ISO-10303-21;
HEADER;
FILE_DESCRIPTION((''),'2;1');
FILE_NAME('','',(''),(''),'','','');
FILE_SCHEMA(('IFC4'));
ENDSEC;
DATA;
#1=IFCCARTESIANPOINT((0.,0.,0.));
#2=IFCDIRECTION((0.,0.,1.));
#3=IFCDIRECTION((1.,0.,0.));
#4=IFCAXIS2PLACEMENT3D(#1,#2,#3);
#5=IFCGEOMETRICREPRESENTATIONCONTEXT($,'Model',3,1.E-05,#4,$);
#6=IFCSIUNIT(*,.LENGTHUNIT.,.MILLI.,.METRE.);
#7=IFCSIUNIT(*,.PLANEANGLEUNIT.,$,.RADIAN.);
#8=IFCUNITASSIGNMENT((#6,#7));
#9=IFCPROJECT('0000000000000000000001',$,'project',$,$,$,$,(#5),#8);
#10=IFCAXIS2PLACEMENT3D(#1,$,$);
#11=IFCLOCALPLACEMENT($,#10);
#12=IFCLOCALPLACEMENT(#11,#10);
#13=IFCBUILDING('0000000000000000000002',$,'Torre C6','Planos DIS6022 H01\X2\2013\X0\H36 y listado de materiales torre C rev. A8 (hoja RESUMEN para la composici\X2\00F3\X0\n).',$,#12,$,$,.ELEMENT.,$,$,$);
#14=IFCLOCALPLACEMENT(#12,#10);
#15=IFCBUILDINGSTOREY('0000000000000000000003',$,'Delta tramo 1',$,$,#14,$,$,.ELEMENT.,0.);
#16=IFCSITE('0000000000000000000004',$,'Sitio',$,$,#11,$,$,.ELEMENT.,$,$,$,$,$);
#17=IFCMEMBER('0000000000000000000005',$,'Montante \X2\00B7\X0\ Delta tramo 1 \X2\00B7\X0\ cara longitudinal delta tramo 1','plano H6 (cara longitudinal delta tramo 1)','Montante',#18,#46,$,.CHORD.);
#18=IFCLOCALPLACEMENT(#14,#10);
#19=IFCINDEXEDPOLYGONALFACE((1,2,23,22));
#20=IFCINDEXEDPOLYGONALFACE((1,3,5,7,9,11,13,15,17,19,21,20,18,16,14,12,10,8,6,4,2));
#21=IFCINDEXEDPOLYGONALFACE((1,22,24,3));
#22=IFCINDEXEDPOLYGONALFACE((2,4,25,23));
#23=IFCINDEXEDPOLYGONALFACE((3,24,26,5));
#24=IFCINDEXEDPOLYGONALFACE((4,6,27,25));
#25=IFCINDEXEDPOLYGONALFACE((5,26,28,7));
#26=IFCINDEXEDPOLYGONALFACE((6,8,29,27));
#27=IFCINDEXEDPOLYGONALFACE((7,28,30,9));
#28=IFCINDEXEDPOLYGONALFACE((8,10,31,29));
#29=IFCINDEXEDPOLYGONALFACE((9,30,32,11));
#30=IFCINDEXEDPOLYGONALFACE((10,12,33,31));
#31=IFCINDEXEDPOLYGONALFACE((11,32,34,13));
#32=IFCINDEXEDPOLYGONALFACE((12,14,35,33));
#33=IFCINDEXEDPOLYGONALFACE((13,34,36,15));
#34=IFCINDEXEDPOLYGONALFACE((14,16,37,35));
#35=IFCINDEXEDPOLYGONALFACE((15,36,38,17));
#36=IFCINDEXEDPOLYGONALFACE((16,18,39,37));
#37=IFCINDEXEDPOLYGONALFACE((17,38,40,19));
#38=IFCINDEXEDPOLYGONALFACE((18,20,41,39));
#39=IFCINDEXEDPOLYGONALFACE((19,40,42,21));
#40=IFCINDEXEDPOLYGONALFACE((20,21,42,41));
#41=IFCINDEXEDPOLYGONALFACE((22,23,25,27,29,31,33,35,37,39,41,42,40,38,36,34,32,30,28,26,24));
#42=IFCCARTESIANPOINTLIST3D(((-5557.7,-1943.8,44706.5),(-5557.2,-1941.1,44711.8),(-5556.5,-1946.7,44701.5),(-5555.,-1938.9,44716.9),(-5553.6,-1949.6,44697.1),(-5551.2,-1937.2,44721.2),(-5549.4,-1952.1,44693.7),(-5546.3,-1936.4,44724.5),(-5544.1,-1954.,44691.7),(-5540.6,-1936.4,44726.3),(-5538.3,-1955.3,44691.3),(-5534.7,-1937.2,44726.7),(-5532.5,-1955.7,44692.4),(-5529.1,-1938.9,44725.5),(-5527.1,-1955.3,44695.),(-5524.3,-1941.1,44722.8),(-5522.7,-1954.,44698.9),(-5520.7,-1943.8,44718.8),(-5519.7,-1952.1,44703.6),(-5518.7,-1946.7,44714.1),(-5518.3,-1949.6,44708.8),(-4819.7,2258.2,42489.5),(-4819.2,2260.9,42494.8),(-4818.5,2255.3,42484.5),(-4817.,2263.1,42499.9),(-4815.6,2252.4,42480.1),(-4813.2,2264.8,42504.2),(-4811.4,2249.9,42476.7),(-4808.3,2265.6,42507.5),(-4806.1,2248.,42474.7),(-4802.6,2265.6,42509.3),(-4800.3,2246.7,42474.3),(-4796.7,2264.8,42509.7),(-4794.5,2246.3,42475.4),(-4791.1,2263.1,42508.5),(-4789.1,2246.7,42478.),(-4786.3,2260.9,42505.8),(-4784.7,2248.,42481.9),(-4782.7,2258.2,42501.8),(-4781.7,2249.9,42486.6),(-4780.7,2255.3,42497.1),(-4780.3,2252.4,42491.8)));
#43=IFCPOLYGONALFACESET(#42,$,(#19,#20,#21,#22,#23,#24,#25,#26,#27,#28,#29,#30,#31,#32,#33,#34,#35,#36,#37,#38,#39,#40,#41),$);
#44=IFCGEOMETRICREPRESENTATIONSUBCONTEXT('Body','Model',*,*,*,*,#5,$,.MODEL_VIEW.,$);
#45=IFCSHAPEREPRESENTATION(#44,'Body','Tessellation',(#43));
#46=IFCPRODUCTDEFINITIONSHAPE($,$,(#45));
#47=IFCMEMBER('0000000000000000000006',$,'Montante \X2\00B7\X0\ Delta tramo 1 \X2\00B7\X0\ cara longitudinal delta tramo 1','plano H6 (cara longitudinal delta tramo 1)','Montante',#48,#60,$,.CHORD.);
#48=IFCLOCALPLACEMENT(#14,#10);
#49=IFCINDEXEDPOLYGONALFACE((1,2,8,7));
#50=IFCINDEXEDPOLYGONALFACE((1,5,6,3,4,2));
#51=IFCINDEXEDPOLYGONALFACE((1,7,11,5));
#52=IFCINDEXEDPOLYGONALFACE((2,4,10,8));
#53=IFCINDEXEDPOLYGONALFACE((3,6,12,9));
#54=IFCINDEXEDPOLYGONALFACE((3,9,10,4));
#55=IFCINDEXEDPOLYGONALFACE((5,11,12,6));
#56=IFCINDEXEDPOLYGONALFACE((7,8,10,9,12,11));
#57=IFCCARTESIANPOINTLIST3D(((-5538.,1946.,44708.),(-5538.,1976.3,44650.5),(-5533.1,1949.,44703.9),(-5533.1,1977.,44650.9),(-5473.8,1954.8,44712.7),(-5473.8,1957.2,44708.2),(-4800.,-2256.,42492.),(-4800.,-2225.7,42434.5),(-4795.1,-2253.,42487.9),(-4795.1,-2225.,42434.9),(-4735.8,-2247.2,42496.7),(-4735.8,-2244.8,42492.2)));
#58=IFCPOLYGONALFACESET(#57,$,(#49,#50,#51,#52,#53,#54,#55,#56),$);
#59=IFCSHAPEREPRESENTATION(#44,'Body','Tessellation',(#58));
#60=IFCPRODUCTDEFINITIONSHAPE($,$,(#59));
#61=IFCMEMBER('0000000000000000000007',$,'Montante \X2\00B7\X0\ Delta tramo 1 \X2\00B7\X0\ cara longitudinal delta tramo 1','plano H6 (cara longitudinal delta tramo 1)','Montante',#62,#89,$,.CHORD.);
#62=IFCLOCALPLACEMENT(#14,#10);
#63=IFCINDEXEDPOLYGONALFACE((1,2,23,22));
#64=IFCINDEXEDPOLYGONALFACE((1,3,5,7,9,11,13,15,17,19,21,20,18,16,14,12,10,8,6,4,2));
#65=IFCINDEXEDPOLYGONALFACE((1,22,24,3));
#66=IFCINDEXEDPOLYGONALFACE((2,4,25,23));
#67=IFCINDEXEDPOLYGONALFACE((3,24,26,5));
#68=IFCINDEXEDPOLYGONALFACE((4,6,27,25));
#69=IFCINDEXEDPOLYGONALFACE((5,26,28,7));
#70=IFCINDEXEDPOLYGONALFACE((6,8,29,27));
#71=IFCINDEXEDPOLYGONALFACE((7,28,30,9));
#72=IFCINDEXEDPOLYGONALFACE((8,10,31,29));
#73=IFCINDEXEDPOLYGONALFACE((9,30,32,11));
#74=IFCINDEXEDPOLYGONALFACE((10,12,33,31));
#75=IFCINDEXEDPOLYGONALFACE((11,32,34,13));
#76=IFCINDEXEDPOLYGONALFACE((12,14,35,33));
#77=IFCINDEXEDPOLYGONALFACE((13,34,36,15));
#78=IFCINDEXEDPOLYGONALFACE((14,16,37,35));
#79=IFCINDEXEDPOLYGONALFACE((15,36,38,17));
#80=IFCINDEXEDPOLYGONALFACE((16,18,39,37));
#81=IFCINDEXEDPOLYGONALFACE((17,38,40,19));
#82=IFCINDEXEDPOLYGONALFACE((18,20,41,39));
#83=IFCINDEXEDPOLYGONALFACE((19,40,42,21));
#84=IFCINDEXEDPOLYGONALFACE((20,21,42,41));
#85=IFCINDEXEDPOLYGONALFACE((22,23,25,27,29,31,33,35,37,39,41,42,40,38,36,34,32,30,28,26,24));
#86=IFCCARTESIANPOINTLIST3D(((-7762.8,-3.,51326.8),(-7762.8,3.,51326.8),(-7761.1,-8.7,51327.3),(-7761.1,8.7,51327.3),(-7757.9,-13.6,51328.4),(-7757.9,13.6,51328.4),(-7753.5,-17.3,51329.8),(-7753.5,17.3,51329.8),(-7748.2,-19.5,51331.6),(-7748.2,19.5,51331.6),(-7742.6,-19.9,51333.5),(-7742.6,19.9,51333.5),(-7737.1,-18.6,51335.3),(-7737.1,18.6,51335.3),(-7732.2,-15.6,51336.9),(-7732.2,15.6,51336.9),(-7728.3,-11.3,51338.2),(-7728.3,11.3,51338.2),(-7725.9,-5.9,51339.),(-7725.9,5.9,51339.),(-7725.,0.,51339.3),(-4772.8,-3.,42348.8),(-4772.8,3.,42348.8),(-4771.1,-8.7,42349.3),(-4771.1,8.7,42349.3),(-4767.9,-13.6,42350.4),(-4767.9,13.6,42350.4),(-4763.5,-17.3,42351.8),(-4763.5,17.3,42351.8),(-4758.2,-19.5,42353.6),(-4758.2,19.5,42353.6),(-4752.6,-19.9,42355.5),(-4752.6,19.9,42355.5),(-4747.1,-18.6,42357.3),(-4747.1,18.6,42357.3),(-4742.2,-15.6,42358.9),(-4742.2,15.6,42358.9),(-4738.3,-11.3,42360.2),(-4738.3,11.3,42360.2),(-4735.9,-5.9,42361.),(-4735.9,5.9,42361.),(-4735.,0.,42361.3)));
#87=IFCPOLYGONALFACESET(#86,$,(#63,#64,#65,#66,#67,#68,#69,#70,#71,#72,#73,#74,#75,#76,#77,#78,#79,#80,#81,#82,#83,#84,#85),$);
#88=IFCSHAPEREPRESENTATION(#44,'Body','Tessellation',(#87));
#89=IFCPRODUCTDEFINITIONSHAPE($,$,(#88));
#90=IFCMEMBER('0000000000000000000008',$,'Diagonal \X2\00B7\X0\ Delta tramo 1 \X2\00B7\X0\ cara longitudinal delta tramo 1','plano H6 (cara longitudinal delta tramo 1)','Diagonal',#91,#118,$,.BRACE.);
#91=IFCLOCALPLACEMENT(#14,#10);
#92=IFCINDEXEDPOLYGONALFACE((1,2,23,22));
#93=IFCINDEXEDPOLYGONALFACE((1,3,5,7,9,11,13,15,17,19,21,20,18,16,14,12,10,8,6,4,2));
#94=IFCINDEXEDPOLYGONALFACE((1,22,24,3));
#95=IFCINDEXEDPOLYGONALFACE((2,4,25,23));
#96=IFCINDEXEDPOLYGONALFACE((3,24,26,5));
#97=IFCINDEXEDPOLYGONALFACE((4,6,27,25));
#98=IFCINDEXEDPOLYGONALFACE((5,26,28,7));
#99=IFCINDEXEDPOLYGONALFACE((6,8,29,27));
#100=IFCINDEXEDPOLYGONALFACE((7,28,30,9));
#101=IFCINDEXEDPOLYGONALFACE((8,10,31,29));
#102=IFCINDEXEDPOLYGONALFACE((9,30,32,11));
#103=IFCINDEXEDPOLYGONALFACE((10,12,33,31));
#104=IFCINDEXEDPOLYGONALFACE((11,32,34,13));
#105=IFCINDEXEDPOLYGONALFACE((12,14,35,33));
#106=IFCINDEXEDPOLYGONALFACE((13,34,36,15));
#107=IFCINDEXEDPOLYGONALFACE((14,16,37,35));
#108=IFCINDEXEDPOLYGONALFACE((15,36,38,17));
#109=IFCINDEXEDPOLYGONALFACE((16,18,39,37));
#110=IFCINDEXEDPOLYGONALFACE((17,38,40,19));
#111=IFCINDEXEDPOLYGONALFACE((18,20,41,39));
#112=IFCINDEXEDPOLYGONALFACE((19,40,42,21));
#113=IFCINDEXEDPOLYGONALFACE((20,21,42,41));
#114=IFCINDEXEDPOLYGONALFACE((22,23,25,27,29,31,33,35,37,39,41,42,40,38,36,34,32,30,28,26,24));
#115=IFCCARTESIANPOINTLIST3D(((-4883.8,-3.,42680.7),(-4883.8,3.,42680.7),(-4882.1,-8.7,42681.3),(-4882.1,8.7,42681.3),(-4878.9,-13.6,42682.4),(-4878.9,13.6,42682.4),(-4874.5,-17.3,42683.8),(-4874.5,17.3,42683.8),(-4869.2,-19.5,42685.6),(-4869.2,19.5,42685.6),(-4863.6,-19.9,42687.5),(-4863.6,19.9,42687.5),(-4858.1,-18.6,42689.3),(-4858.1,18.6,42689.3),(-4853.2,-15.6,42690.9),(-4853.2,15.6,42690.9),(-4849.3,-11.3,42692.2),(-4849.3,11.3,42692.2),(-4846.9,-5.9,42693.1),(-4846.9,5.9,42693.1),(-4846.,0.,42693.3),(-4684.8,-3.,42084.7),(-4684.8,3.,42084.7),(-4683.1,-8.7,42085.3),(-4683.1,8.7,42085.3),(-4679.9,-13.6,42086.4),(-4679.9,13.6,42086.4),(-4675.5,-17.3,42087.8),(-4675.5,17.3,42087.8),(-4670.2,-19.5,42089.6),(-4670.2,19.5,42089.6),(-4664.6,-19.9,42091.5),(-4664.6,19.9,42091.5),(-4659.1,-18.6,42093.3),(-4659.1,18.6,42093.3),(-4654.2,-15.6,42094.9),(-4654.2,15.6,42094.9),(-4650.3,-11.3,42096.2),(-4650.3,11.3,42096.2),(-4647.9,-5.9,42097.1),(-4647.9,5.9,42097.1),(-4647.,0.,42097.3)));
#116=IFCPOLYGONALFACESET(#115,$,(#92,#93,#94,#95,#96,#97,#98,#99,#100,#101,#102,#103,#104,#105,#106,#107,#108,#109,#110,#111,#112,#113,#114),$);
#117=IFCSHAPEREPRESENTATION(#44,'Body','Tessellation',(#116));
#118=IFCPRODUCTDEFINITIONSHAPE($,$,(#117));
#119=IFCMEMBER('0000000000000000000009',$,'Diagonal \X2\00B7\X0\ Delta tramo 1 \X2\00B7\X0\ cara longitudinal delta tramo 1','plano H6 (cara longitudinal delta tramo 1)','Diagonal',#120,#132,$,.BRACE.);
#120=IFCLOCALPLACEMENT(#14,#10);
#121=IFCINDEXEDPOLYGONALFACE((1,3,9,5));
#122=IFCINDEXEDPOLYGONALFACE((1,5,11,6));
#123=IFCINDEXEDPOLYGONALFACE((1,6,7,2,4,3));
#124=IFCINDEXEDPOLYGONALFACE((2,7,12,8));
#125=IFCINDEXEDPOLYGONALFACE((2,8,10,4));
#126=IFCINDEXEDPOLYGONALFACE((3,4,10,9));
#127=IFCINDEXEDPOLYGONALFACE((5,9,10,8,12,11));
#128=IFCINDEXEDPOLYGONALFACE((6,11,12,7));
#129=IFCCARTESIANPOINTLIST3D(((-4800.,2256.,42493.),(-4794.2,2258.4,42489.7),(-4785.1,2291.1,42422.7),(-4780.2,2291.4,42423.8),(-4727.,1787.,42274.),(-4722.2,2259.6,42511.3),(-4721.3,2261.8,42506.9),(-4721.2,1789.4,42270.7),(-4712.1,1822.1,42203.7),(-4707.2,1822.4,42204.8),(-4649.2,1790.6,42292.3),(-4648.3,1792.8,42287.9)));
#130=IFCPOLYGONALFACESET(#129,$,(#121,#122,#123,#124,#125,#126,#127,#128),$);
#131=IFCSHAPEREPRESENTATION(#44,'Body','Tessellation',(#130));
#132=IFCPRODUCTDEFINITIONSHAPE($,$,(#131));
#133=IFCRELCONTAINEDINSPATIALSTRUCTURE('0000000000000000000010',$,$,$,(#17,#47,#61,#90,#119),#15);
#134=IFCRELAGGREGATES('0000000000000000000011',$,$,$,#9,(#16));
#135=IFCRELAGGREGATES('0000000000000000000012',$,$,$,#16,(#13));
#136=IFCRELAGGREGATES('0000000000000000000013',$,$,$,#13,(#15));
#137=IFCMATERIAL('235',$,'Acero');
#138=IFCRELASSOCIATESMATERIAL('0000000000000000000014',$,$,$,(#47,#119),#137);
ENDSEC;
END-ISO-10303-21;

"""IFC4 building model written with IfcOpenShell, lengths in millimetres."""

from ifc_helpers import new_model, si_unit, frame, frame_2d, origin, origin_with_axes, place, context, subcontext, project, spatial, circle, l_section, extrude, material, element, save


model = new_model("IFC4")

# Units and contexts
model_context = context("Model", 3, precision=1e-05, world=origin_with_axes())
body_context = subcontext(model_context, "Body", "Model", "MODEL_VIEW")
ifc_project = project(units=[si_unit("LENGTHUNIT", "METRE", prefix="MILLI"), si_unit("PLANEANGLEUNIT", "RADIAN")], contexts=[model_context])

# Site, building, storey
site_placement = place(None, origin())
site = spatial("IfcSite", under=ifc_project, at=site_placement, Name="Sitio", CompositionType="ELEMENT")
building_placement = place(site_placement, origin())
building = spatial("IfcBuilding", under=site, at=building_placement, Name="Torre C6", Description="Planos DIS6022 H01–H36 y listado de materiales torre C rev. A8 (hoja RESUMEN para la composición).", CompositionType="ELEMENT")
storey_placement = place(building_placement, origin())
storey = spatial("IfcBuildingStorey", under=building, at=storey_placement, Name="Delta tramo 1", CompositionType="ELEMENT", Elevation=0.0)

# Members
member_1_placement = place(storey_placement, frame((-4800.0, 2256.0, 42492.0), z_axis=(-0.153495, -0.873966, 0.46111), x_axis=(0.276036, -0.485987, -0.829229)))
element("IfcMember", 1, at=member_1_placement, inside=storey, Name="Montante · Delta tramo 1 · cara longitudinal delta tramo 1", Description="plano H6 (cara longitudinal delta tramo 1)", ObjectType="Montante", PredefinedType="CHORD", context=body_context, shape_type="SweptSolid", body=[
    extrude(circle(Radius=20.0), None, (0.0, 0.0, 1.0), 4808.0),
])
ifc_material_1 = material(Name="235", Category="Acero")
member_2_placement = place(storey_placement, frame((-4800.0, -2256.0, 42492.0), z_axis=(-0.15351, 0.87405, 0.460946), x_axis=(0.988147, 0.135785, 0.071609)))
element("IfcMember", 2, at=member_2_placement, inside=storey, material=ifc_material_1, Name="Montante · Delta tramo 1 · cara longitudinal delta tramo 1", Description="plano H6 (cara longitudinal delta tramo 1)", ObjectType="Montante", PredefinedType="CHORD", context=body_context, shape_type="SweptSolid", body=[
    extrude(l_section(Depth=65.0, Width=65.0, Thickness=5.0, at=frame_2d((32.5, 32.5))), None, (0.0, 0.0, 1.0), 4807.5),
])
member_3_placement = place(storey_placement, frame((-4754.0, 0.0, 42355.0), z_axis=(-0.315974, 0.0, 0.948768), x_axis=(0.948768, 0.0, 0.315974)))
element("IfcMember", 3, at=member_3_placement, inside=storey, Name="Montante · Delta tramo 1 · cara longitudinal delta tramo 1", Description="plano H6 (cara longitudinal delta tramo 1)", ObjectType="Montante", PredefinedType="CHORD", context=body_context, shape_type="SweptSolid", body=[
    extrude(circle(Radius=20.0), None, (0.0, 0.0, 1.0), 9462.8),
])
member_4_placement = place(storey_placement, frame((-4666.0, 0.0, 42091.0), z_axis=(-0.316705, 0.0, 0.948524), x_axis=(0.948524, 0.0, 0.316705)))
element("IfcMember", 4, at=member_4_placement, inside=storey, Name="Diagonal · Delta tramo 1 · cara longitudinal delta tramo 1", Description="plano H6 (cara longitudinal delta tramo 1)", ObjectType="Diagonal", PredefinedType="BRACE", context=body_context, shape_type="SweptSolid", body=[
    extrude(circle(Radius=20.0), None, (0.0, 0.0, 1.0), 628.3),
])
member_5_placement = place(storey_placement, frame((-4727.0, 1787.0, 42274.0), z_axis=(-0.13965, 0.897206, 0.418951), x_axis=(0.972489, 0.044604, 0.22864)))
element("IfcMember", 5, at=member_5_placement, inside=storey, material=ifc_material_1, Name="Diagonal · Delta tramo 1 · cara longitudinal delta tramo 1", Description="plano H6 (cara longitudinal delta tramo 1)", ObjectType="Diagonal", PredefinedType="BRACE", context=body_context, shape_type="SweptSolid", body=[
    extrude(l_section(Depth=80.0, Width=80.0, Thickness=5.0, at=frame_2d((40.0, 40.0))), None, (0.0, 0.0, 1.0), 522.7),
])

save(model, "model.ifc")
